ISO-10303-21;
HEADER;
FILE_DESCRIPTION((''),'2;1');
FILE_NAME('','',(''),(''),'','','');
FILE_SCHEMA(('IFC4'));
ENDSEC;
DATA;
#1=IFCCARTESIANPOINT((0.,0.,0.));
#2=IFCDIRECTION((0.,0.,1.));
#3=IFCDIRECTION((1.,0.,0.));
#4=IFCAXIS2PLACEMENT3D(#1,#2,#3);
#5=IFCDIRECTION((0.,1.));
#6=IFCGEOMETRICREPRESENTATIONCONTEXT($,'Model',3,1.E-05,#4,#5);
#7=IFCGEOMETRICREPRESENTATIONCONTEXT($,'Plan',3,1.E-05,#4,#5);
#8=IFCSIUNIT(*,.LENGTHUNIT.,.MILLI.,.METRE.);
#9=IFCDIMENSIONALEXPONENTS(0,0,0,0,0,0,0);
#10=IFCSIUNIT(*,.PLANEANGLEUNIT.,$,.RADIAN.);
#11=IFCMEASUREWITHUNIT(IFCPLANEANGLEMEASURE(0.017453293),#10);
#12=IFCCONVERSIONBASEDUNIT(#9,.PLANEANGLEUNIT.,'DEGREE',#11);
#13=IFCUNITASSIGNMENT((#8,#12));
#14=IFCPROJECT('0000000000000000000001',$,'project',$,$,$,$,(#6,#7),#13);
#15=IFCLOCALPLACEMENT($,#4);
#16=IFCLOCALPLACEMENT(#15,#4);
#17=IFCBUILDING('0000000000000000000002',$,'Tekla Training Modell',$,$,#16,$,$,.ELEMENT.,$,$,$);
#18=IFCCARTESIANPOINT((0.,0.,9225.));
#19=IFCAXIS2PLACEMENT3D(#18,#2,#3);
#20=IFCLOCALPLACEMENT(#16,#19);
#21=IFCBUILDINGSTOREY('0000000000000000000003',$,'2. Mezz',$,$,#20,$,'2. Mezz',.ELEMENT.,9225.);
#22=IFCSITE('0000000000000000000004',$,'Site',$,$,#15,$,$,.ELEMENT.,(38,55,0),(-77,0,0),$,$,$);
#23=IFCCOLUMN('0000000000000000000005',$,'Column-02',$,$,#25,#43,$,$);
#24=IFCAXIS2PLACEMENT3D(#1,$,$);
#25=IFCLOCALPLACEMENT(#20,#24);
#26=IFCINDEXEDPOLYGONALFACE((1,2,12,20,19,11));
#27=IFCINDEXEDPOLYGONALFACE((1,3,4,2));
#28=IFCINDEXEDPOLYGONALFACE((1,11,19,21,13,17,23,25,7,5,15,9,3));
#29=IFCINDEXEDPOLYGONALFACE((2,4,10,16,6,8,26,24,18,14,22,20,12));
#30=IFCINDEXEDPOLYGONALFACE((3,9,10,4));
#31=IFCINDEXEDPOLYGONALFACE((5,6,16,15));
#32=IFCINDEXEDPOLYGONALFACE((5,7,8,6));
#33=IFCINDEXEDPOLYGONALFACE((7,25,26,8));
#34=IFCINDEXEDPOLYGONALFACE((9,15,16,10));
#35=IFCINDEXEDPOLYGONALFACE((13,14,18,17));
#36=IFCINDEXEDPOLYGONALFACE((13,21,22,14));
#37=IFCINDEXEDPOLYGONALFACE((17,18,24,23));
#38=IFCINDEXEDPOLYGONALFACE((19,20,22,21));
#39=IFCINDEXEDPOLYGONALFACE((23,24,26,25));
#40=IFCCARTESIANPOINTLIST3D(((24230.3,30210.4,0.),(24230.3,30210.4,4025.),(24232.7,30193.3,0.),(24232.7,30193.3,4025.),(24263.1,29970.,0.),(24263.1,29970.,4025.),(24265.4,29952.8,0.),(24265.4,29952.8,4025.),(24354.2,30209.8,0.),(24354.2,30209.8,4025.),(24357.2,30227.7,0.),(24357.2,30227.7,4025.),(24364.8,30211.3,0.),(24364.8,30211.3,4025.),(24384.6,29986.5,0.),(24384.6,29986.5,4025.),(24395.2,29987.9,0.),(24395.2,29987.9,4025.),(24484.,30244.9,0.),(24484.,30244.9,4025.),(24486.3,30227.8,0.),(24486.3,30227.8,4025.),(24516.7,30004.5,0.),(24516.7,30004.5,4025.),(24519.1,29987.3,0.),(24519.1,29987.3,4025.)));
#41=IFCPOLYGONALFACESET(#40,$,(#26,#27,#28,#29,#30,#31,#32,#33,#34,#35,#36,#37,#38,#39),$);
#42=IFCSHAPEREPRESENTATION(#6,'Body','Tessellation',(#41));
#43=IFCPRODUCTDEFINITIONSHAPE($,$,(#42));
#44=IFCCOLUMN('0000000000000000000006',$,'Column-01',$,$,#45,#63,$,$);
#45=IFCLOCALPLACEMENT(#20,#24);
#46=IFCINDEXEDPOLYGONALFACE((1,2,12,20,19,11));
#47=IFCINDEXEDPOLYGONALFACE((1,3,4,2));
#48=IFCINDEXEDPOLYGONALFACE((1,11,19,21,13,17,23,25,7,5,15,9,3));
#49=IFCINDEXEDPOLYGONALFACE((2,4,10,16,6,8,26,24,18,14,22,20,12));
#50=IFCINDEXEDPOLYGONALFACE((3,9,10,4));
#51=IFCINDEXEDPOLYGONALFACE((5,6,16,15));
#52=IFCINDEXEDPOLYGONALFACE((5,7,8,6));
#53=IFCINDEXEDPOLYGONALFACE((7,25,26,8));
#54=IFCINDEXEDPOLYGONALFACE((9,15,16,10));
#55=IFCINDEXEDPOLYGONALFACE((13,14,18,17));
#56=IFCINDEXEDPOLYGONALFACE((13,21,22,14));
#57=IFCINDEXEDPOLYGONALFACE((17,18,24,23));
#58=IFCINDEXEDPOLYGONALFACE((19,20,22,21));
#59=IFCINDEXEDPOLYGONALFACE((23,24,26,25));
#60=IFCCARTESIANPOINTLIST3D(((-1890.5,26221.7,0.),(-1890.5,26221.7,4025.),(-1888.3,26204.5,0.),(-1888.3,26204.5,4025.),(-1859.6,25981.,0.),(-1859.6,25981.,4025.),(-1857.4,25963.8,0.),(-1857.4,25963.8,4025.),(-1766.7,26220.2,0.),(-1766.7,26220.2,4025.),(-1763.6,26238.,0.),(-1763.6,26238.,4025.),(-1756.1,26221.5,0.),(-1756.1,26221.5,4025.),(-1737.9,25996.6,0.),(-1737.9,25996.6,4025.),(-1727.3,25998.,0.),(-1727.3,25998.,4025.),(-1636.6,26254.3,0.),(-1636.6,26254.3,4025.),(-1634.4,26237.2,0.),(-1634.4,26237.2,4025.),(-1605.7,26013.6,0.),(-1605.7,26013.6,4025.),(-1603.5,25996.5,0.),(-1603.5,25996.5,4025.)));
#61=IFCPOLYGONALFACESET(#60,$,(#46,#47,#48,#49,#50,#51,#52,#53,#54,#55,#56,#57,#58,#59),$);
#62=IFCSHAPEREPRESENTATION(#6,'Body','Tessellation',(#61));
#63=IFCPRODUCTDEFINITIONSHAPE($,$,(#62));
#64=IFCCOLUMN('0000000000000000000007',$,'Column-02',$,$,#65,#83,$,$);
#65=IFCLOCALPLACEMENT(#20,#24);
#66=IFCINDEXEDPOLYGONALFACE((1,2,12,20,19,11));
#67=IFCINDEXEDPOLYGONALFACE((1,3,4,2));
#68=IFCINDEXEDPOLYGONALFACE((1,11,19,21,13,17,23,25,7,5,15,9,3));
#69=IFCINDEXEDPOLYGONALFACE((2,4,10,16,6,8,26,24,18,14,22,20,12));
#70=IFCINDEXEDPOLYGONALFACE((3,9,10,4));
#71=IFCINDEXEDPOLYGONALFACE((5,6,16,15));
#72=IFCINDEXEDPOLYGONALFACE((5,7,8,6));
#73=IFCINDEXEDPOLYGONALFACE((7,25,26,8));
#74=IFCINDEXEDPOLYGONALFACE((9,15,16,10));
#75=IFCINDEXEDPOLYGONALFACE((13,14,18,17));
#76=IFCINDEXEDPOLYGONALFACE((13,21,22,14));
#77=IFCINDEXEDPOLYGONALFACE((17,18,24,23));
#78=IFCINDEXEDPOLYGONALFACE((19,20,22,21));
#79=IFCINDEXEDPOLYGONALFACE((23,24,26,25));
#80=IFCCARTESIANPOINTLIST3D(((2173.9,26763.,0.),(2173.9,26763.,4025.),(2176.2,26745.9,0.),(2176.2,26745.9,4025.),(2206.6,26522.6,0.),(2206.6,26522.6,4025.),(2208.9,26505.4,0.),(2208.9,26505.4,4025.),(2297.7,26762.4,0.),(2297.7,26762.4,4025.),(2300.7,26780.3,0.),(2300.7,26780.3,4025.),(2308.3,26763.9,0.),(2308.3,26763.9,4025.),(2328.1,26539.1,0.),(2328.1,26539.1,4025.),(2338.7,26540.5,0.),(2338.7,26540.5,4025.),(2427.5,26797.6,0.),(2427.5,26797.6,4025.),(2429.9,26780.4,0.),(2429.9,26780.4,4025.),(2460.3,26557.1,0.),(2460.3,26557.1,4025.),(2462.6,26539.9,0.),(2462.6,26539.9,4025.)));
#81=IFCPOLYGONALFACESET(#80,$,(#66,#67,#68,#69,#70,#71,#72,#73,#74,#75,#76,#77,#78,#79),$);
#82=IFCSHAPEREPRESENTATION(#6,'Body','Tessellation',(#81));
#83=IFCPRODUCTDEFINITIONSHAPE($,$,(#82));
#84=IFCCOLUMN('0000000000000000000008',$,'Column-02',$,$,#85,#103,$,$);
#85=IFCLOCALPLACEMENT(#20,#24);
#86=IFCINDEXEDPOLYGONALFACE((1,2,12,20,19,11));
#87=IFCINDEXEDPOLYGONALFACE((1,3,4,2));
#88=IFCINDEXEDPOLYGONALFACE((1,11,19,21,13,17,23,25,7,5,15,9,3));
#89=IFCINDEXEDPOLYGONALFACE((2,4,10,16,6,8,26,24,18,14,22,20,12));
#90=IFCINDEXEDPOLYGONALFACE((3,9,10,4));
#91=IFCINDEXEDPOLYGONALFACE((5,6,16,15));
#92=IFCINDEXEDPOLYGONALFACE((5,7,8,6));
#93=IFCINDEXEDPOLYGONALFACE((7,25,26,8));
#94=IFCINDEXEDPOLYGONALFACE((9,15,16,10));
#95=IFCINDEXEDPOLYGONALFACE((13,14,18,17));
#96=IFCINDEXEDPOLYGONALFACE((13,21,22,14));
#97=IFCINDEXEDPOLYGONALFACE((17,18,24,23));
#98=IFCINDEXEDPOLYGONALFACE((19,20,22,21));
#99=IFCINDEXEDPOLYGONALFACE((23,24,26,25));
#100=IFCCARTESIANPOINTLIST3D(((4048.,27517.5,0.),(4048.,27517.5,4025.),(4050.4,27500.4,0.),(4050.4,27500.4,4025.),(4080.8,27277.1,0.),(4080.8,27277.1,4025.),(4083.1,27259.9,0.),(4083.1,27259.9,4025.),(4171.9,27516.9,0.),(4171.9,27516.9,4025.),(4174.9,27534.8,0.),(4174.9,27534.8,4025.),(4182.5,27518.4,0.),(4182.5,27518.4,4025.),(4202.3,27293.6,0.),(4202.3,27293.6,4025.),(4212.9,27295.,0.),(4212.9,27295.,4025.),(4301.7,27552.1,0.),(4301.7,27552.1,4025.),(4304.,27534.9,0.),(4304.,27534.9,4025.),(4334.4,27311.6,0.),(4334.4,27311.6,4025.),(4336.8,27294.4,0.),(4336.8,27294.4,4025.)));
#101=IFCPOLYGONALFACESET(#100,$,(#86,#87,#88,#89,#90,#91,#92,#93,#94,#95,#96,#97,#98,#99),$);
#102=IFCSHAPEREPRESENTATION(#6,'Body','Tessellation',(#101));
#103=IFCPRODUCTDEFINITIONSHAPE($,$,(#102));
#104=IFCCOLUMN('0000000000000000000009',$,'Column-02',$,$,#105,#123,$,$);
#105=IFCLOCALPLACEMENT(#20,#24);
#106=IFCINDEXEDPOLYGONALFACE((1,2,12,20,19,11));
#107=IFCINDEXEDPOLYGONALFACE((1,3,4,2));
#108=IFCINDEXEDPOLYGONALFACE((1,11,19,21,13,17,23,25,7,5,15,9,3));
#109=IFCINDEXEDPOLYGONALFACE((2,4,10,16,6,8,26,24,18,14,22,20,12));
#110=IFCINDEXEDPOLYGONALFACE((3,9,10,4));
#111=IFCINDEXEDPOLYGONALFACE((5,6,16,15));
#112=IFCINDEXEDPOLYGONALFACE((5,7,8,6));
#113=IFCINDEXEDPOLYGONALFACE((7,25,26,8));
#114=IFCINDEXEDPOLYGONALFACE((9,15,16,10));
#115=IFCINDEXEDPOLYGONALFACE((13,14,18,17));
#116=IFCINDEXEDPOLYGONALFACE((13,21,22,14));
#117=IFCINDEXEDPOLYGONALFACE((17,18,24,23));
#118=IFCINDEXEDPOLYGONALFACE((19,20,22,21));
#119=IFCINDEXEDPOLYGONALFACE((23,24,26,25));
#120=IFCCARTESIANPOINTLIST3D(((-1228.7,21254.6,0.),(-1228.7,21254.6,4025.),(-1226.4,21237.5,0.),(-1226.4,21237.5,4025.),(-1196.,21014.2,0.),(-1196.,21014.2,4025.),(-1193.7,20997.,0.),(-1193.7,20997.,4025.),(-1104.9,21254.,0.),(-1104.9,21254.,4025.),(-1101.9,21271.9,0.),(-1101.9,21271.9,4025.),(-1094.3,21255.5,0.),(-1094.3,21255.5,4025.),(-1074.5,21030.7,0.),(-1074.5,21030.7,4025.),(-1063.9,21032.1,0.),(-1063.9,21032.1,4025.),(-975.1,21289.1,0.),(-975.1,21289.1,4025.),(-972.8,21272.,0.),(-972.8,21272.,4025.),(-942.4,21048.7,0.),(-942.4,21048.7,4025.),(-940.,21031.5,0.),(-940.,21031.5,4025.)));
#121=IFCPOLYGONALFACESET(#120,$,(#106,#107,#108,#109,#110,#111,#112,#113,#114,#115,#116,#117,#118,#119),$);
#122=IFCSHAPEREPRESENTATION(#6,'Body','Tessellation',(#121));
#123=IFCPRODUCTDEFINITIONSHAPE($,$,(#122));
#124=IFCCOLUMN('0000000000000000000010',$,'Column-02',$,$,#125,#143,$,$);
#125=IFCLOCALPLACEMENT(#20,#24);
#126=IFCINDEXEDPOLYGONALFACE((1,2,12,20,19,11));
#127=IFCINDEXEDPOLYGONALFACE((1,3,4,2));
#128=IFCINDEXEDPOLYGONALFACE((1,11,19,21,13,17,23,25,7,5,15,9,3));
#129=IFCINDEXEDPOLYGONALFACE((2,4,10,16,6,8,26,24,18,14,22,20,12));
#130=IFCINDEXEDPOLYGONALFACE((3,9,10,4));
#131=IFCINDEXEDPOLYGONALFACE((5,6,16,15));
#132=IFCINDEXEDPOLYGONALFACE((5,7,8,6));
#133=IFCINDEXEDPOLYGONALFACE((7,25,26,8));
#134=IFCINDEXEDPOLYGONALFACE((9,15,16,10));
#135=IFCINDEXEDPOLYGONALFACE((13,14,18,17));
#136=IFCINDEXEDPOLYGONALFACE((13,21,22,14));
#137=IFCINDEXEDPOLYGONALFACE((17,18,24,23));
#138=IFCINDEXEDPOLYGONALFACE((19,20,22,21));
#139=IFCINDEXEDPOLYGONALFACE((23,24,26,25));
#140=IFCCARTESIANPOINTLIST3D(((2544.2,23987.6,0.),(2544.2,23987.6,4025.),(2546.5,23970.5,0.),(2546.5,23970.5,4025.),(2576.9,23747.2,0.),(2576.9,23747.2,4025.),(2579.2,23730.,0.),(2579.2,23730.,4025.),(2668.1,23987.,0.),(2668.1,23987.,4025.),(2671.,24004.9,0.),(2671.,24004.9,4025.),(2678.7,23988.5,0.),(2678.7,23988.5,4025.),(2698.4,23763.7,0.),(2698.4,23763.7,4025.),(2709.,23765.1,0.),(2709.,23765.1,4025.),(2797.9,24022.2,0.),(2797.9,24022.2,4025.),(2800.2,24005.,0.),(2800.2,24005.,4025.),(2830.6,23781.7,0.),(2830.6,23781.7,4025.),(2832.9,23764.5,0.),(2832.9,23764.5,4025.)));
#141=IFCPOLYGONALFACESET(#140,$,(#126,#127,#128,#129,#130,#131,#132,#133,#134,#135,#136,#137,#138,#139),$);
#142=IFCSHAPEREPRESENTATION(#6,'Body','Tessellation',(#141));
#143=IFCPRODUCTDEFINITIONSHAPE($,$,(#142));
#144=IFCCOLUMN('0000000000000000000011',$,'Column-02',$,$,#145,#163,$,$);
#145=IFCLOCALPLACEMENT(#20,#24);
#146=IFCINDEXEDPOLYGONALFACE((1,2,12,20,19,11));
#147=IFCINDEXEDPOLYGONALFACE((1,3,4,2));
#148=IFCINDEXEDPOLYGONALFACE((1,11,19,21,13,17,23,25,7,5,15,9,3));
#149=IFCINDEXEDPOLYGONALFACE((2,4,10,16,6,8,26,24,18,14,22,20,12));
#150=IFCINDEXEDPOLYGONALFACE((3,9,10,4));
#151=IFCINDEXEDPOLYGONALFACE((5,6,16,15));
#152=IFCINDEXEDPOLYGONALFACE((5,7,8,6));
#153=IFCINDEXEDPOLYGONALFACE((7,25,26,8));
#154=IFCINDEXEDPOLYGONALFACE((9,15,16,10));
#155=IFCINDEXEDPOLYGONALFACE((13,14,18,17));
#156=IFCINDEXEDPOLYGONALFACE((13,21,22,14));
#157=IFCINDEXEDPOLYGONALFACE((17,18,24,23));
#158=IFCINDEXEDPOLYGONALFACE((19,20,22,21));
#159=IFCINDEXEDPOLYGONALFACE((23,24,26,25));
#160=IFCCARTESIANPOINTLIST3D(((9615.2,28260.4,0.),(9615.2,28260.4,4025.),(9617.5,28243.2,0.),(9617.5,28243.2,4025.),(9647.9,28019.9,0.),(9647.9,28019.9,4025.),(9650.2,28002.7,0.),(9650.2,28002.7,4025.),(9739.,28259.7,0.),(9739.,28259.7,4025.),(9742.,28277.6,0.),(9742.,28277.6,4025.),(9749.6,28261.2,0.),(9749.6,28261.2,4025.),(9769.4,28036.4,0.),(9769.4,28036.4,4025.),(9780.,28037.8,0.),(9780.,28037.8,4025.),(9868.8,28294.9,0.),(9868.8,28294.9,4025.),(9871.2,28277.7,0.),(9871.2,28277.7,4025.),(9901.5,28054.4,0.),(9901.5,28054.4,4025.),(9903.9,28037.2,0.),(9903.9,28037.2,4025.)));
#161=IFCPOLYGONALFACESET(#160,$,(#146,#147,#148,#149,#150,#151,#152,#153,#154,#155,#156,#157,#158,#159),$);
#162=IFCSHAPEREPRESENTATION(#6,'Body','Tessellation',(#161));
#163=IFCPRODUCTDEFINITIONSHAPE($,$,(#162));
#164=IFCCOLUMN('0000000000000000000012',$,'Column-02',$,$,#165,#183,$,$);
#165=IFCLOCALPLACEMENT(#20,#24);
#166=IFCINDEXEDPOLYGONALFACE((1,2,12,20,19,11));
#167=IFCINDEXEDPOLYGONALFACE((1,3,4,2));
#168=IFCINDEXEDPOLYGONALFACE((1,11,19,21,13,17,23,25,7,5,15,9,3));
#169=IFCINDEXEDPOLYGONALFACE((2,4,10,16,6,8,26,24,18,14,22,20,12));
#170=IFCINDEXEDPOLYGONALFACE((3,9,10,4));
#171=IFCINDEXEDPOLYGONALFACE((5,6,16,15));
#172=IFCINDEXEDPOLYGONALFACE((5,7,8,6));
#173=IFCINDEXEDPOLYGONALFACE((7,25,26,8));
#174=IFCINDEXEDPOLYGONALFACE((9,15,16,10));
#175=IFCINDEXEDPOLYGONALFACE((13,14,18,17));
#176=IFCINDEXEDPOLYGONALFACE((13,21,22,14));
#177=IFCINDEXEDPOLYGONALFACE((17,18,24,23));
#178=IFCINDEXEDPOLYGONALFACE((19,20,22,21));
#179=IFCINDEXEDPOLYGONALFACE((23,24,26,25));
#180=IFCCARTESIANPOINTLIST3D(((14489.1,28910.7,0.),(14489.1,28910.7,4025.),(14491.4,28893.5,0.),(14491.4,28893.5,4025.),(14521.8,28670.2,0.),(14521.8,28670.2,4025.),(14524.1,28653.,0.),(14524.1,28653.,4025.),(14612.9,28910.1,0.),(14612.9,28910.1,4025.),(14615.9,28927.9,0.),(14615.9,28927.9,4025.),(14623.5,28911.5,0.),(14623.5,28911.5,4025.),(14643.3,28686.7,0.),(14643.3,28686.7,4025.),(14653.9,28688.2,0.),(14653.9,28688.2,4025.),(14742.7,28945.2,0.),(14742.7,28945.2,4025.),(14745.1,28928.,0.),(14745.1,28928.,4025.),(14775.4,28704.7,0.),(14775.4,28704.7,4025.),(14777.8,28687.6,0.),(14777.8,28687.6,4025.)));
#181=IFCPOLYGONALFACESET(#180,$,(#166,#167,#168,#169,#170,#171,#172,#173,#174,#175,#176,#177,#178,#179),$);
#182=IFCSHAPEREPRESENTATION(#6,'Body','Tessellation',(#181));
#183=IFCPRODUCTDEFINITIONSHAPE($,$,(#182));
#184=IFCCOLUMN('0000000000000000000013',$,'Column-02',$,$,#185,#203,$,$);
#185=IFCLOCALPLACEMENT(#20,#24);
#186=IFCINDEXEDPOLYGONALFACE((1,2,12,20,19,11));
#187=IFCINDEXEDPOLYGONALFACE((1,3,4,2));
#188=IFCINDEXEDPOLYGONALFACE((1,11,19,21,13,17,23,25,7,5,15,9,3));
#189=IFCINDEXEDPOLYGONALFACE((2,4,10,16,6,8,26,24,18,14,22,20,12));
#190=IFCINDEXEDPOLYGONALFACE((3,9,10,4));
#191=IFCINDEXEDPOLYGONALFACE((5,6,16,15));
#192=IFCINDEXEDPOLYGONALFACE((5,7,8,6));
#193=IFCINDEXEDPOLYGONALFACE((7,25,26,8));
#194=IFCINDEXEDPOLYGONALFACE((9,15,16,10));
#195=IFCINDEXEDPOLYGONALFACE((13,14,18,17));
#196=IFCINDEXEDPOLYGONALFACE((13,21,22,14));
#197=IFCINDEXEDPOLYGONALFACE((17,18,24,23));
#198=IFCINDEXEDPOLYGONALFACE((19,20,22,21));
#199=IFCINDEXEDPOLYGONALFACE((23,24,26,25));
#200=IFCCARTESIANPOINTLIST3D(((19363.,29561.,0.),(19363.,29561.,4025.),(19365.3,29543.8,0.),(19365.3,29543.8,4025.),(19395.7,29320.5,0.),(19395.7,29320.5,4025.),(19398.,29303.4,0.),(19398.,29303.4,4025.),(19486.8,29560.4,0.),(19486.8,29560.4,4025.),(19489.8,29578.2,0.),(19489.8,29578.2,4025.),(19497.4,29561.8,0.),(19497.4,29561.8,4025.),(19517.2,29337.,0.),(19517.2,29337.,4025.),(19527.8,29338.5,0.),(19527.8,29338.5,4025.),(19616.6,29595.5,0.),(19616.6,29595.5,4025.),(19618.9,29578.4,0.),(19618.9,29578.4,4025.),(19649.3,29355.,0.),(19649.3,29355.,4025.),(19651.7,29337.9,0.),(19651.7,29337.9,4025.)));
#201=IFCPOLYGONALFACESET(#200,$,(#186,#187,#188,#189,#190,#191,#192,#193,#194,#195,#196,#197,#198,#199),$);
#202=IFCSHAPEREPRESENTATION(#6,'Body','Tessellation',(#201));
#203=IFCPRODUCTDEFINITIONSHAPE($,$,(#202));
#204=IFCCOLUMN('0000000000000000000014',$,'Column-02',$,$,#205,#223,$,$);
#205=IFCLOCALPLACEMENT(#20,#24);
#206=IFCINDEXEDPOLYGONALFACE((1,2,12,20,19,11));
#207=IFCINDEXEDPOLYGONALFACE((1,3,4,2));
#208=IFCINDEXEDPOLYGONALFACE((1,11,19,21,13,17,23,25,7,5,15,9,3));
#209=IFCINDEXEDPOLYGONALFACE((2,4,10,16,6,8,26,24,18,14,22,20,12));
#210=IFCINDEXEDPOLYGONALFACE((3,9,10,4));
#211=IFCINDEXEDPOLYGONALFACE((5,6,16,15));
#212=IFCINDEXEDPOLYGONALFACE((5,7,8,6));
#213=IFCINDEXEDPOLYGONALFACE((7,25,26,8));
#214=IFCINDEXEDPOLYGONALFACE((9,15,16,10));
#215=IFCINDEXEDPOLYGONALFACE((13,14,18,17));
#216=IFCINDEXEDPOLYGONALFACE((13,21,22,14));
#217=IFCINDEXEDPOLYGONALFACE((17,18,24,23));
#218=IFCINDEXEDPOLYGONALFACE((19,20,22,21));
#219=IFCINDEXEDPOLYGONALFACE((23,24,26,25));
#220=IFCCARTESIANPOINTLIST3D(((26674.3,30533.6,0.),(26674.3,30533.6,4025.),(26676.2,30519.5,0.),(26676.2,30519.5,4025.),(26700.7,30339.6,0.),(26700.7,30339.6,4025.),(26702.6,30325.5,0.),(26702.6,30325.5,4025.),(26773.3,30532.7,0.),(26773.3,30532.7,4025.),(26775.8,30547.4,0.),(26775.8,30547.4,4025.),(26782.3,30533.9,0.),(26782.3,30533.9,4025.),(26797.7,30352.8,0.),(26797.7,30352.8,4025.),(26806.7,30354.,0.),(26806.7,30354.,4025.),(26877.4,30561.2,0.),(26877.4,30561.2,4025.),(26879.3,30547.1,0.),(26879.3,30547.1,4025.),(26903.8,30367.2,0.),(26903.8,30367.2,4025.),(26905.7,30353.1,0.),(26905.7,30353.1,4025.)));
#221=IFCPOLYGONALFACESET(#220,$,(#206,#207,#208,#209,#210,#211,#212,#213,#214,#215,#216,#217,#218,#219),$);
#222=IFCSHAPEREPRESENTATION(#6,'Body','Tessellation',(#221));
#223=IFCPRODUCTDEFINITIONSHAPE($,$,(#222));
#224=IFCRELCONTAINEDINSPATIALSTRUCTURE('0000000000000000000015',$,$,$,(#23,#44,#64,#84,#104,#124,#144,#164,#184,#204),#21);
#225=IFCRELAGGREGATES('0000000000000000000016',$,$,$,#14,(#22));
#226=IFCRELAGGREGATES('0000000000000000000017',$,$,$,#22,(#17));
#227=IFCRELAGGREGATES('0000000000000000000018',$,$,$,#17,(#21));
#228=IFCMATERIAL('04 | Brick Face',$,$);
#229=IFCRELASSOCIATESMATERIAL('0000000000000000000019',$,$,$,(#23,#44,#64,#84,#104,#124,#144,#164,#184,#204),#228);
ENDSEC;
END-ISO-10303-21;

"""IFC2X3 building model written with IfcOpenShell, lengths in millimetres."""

from ifc_helpers import new_model, entity, si_unit, converted_unit, direction, frame, origin_with_axes, place, context, project, spatial, polyline, outline, extrude, material, element, save


model = new_model("IFC2X3")

# Units and contexts
model_context = context("Model", 3, precision=1e-05, world=origin_with_axes(), true_north=direction((0.0, 1.0)))
plan_context = context("Plan", 3, precision=1e-05, world=origin_with_axes(), true_north=direction((0.0, 1.0)))
ifc_project = project(units=[si_unit("LENGTHUNIT", "METRE", prefix="MILLI"), converted_unit("PLANEANGLEUNIT", "DEGREE", entity("IfcPlaneAngleMeasure", 0.017453293), si_unit("PLANEANGLEUNIT", "RADIAN"), dimensions=[0, 0, 0, 0, 0, 0, 0])], contexts=[model_context, plan_context])

# Site, building, storey
site_placement = place(None, origin_with_axes())
site = spatial("IfcSite", under=ifc_project, at=site_placement, Name="Site", CompositionType="ELEMENT", RefLatitude=(38, 55, 0), RefLongitude=(-77, 0, 0))
building_placement = place(site_placement, origin_with_axes())
building = spatial("IfcBuilding", under=site, at=building_placement, Name="Tekla Training Modell", CompositionType="ELEMENT")
storey_placement = place(building_placement, frame((0.0, 0.0, 9225.0), z_axis=(0.0, 0.0, 1.0), x_axis=(1.0, 0.0, 0.0)))
storey = spatial("IfcBuildingStorey", under=building, at=storey_placement, Name="2. Mezz", LongName="2. Mezz", CompositionType="ELEMENT", Elevation=9225.0)

# Columns
ifc_material_1 = material(Name="04 | Brick Face")
for number, where, z_axis, x_axis, name in (
    (1, (24374.7, 30098.9, 0.0), (0.0, 0.0, 1.0), (0.990872, 0.134803, 0.0), "Column-02"),
    (2, (-1747.0, 26109.1, 0.0), (0.0, 0.0, 1.0), (0.991827, 0.127587, 0.0), "Column-01"),
    (3, (2318.2, 26651.5, 0.0), (0.0, 0.0, 1.0), (0.990872, 0.134803, 0.0), "Column-02"),
    (4, (4192.4, 27406.0, 0.0), (0.0, 0.0, 1.0), (0.990872, 0.134803, 0.0), "Column-02"),
    (5, (-1084.4, 21143.1, 0.0), (0.0, 0.0, 1.0), (0.990872, 0.134803, 0.0), "Column-02"),
    (6, (2688.5, 23876.1, 0.0), (0.0, 0.0, 1.0), (0.990872, 0.134803, 0.0), "Column-02"),
    (7, (9759.5, 28148.8, 0.0), (0.0, 0.0, 1.0), (0.990872, 0.134803, 0.0), "Column-02"),
    (8, (14633.4, 28799.1, 0.0), (0.0, 0.0, 1.0), (0.990872, 0.134803, 0.0), "Column-02"),
    (9, (19507.3, 29449.4, 0.0), (0.0, 0.0, 1.0), (0.990872, 0.134803, 0.0), "Column-02"),
):
    element("IfcColumn", number, at=place(storey_placement, frame(where, z_axis=z_axis, x_axis=x_axis)), inside=storey, material=ifc_material_1, Name=name, context=model_context, shape_type="SweptSolid", body=[
        extrude(outline(polyline([(0.0, 130.0), (-128.0, 130.0), (-128.0, 112.7), (-5.3, 112.7), (-5.3, -112.7), (-128.0, -112.7), (-128.0, -130.0), (128.0, -130.0), (128.0, -112.7), (5.3, -112.7), (5.3, 112.7), (128.0, 112.7), (128.0, 130.0), (0.0, 130.0)])), origin_with_axes(), (0.0, 0.0, 1.0), 4025.0),
    ])
column_placement = place(storey_placement, frame((26790.0, 30443.4, 0.0), z_axis=(0.0, 0.0, 1.0), x_axis=(0.990872, 0.134803, 0.0)))
element("IfcColumn", 10, at=column_placement, inside=storey, material=ifc_material_1, Name="Column-02", context=model_context, shape_type="SweptSolid", body=[
    extrude(outline(polyline([(0.0, 105.0), (-102.5, 105.0), (-102.5, 90.8), (-4.5, 90.8), (-4.5, -90.8), (-102.5, -90.8), (-102.5, -105.0), (102.5, -105.0), (102.5, -90.8), (4.5, -90.8), (4.5, 90.8), (102.5, 90.8), (102.5, 105.0), (0.0, 105.0)])), origin_with_axes(), (0.0, 0.0, 1.0), 4025.0),
])

save(model, "model.ifc")
